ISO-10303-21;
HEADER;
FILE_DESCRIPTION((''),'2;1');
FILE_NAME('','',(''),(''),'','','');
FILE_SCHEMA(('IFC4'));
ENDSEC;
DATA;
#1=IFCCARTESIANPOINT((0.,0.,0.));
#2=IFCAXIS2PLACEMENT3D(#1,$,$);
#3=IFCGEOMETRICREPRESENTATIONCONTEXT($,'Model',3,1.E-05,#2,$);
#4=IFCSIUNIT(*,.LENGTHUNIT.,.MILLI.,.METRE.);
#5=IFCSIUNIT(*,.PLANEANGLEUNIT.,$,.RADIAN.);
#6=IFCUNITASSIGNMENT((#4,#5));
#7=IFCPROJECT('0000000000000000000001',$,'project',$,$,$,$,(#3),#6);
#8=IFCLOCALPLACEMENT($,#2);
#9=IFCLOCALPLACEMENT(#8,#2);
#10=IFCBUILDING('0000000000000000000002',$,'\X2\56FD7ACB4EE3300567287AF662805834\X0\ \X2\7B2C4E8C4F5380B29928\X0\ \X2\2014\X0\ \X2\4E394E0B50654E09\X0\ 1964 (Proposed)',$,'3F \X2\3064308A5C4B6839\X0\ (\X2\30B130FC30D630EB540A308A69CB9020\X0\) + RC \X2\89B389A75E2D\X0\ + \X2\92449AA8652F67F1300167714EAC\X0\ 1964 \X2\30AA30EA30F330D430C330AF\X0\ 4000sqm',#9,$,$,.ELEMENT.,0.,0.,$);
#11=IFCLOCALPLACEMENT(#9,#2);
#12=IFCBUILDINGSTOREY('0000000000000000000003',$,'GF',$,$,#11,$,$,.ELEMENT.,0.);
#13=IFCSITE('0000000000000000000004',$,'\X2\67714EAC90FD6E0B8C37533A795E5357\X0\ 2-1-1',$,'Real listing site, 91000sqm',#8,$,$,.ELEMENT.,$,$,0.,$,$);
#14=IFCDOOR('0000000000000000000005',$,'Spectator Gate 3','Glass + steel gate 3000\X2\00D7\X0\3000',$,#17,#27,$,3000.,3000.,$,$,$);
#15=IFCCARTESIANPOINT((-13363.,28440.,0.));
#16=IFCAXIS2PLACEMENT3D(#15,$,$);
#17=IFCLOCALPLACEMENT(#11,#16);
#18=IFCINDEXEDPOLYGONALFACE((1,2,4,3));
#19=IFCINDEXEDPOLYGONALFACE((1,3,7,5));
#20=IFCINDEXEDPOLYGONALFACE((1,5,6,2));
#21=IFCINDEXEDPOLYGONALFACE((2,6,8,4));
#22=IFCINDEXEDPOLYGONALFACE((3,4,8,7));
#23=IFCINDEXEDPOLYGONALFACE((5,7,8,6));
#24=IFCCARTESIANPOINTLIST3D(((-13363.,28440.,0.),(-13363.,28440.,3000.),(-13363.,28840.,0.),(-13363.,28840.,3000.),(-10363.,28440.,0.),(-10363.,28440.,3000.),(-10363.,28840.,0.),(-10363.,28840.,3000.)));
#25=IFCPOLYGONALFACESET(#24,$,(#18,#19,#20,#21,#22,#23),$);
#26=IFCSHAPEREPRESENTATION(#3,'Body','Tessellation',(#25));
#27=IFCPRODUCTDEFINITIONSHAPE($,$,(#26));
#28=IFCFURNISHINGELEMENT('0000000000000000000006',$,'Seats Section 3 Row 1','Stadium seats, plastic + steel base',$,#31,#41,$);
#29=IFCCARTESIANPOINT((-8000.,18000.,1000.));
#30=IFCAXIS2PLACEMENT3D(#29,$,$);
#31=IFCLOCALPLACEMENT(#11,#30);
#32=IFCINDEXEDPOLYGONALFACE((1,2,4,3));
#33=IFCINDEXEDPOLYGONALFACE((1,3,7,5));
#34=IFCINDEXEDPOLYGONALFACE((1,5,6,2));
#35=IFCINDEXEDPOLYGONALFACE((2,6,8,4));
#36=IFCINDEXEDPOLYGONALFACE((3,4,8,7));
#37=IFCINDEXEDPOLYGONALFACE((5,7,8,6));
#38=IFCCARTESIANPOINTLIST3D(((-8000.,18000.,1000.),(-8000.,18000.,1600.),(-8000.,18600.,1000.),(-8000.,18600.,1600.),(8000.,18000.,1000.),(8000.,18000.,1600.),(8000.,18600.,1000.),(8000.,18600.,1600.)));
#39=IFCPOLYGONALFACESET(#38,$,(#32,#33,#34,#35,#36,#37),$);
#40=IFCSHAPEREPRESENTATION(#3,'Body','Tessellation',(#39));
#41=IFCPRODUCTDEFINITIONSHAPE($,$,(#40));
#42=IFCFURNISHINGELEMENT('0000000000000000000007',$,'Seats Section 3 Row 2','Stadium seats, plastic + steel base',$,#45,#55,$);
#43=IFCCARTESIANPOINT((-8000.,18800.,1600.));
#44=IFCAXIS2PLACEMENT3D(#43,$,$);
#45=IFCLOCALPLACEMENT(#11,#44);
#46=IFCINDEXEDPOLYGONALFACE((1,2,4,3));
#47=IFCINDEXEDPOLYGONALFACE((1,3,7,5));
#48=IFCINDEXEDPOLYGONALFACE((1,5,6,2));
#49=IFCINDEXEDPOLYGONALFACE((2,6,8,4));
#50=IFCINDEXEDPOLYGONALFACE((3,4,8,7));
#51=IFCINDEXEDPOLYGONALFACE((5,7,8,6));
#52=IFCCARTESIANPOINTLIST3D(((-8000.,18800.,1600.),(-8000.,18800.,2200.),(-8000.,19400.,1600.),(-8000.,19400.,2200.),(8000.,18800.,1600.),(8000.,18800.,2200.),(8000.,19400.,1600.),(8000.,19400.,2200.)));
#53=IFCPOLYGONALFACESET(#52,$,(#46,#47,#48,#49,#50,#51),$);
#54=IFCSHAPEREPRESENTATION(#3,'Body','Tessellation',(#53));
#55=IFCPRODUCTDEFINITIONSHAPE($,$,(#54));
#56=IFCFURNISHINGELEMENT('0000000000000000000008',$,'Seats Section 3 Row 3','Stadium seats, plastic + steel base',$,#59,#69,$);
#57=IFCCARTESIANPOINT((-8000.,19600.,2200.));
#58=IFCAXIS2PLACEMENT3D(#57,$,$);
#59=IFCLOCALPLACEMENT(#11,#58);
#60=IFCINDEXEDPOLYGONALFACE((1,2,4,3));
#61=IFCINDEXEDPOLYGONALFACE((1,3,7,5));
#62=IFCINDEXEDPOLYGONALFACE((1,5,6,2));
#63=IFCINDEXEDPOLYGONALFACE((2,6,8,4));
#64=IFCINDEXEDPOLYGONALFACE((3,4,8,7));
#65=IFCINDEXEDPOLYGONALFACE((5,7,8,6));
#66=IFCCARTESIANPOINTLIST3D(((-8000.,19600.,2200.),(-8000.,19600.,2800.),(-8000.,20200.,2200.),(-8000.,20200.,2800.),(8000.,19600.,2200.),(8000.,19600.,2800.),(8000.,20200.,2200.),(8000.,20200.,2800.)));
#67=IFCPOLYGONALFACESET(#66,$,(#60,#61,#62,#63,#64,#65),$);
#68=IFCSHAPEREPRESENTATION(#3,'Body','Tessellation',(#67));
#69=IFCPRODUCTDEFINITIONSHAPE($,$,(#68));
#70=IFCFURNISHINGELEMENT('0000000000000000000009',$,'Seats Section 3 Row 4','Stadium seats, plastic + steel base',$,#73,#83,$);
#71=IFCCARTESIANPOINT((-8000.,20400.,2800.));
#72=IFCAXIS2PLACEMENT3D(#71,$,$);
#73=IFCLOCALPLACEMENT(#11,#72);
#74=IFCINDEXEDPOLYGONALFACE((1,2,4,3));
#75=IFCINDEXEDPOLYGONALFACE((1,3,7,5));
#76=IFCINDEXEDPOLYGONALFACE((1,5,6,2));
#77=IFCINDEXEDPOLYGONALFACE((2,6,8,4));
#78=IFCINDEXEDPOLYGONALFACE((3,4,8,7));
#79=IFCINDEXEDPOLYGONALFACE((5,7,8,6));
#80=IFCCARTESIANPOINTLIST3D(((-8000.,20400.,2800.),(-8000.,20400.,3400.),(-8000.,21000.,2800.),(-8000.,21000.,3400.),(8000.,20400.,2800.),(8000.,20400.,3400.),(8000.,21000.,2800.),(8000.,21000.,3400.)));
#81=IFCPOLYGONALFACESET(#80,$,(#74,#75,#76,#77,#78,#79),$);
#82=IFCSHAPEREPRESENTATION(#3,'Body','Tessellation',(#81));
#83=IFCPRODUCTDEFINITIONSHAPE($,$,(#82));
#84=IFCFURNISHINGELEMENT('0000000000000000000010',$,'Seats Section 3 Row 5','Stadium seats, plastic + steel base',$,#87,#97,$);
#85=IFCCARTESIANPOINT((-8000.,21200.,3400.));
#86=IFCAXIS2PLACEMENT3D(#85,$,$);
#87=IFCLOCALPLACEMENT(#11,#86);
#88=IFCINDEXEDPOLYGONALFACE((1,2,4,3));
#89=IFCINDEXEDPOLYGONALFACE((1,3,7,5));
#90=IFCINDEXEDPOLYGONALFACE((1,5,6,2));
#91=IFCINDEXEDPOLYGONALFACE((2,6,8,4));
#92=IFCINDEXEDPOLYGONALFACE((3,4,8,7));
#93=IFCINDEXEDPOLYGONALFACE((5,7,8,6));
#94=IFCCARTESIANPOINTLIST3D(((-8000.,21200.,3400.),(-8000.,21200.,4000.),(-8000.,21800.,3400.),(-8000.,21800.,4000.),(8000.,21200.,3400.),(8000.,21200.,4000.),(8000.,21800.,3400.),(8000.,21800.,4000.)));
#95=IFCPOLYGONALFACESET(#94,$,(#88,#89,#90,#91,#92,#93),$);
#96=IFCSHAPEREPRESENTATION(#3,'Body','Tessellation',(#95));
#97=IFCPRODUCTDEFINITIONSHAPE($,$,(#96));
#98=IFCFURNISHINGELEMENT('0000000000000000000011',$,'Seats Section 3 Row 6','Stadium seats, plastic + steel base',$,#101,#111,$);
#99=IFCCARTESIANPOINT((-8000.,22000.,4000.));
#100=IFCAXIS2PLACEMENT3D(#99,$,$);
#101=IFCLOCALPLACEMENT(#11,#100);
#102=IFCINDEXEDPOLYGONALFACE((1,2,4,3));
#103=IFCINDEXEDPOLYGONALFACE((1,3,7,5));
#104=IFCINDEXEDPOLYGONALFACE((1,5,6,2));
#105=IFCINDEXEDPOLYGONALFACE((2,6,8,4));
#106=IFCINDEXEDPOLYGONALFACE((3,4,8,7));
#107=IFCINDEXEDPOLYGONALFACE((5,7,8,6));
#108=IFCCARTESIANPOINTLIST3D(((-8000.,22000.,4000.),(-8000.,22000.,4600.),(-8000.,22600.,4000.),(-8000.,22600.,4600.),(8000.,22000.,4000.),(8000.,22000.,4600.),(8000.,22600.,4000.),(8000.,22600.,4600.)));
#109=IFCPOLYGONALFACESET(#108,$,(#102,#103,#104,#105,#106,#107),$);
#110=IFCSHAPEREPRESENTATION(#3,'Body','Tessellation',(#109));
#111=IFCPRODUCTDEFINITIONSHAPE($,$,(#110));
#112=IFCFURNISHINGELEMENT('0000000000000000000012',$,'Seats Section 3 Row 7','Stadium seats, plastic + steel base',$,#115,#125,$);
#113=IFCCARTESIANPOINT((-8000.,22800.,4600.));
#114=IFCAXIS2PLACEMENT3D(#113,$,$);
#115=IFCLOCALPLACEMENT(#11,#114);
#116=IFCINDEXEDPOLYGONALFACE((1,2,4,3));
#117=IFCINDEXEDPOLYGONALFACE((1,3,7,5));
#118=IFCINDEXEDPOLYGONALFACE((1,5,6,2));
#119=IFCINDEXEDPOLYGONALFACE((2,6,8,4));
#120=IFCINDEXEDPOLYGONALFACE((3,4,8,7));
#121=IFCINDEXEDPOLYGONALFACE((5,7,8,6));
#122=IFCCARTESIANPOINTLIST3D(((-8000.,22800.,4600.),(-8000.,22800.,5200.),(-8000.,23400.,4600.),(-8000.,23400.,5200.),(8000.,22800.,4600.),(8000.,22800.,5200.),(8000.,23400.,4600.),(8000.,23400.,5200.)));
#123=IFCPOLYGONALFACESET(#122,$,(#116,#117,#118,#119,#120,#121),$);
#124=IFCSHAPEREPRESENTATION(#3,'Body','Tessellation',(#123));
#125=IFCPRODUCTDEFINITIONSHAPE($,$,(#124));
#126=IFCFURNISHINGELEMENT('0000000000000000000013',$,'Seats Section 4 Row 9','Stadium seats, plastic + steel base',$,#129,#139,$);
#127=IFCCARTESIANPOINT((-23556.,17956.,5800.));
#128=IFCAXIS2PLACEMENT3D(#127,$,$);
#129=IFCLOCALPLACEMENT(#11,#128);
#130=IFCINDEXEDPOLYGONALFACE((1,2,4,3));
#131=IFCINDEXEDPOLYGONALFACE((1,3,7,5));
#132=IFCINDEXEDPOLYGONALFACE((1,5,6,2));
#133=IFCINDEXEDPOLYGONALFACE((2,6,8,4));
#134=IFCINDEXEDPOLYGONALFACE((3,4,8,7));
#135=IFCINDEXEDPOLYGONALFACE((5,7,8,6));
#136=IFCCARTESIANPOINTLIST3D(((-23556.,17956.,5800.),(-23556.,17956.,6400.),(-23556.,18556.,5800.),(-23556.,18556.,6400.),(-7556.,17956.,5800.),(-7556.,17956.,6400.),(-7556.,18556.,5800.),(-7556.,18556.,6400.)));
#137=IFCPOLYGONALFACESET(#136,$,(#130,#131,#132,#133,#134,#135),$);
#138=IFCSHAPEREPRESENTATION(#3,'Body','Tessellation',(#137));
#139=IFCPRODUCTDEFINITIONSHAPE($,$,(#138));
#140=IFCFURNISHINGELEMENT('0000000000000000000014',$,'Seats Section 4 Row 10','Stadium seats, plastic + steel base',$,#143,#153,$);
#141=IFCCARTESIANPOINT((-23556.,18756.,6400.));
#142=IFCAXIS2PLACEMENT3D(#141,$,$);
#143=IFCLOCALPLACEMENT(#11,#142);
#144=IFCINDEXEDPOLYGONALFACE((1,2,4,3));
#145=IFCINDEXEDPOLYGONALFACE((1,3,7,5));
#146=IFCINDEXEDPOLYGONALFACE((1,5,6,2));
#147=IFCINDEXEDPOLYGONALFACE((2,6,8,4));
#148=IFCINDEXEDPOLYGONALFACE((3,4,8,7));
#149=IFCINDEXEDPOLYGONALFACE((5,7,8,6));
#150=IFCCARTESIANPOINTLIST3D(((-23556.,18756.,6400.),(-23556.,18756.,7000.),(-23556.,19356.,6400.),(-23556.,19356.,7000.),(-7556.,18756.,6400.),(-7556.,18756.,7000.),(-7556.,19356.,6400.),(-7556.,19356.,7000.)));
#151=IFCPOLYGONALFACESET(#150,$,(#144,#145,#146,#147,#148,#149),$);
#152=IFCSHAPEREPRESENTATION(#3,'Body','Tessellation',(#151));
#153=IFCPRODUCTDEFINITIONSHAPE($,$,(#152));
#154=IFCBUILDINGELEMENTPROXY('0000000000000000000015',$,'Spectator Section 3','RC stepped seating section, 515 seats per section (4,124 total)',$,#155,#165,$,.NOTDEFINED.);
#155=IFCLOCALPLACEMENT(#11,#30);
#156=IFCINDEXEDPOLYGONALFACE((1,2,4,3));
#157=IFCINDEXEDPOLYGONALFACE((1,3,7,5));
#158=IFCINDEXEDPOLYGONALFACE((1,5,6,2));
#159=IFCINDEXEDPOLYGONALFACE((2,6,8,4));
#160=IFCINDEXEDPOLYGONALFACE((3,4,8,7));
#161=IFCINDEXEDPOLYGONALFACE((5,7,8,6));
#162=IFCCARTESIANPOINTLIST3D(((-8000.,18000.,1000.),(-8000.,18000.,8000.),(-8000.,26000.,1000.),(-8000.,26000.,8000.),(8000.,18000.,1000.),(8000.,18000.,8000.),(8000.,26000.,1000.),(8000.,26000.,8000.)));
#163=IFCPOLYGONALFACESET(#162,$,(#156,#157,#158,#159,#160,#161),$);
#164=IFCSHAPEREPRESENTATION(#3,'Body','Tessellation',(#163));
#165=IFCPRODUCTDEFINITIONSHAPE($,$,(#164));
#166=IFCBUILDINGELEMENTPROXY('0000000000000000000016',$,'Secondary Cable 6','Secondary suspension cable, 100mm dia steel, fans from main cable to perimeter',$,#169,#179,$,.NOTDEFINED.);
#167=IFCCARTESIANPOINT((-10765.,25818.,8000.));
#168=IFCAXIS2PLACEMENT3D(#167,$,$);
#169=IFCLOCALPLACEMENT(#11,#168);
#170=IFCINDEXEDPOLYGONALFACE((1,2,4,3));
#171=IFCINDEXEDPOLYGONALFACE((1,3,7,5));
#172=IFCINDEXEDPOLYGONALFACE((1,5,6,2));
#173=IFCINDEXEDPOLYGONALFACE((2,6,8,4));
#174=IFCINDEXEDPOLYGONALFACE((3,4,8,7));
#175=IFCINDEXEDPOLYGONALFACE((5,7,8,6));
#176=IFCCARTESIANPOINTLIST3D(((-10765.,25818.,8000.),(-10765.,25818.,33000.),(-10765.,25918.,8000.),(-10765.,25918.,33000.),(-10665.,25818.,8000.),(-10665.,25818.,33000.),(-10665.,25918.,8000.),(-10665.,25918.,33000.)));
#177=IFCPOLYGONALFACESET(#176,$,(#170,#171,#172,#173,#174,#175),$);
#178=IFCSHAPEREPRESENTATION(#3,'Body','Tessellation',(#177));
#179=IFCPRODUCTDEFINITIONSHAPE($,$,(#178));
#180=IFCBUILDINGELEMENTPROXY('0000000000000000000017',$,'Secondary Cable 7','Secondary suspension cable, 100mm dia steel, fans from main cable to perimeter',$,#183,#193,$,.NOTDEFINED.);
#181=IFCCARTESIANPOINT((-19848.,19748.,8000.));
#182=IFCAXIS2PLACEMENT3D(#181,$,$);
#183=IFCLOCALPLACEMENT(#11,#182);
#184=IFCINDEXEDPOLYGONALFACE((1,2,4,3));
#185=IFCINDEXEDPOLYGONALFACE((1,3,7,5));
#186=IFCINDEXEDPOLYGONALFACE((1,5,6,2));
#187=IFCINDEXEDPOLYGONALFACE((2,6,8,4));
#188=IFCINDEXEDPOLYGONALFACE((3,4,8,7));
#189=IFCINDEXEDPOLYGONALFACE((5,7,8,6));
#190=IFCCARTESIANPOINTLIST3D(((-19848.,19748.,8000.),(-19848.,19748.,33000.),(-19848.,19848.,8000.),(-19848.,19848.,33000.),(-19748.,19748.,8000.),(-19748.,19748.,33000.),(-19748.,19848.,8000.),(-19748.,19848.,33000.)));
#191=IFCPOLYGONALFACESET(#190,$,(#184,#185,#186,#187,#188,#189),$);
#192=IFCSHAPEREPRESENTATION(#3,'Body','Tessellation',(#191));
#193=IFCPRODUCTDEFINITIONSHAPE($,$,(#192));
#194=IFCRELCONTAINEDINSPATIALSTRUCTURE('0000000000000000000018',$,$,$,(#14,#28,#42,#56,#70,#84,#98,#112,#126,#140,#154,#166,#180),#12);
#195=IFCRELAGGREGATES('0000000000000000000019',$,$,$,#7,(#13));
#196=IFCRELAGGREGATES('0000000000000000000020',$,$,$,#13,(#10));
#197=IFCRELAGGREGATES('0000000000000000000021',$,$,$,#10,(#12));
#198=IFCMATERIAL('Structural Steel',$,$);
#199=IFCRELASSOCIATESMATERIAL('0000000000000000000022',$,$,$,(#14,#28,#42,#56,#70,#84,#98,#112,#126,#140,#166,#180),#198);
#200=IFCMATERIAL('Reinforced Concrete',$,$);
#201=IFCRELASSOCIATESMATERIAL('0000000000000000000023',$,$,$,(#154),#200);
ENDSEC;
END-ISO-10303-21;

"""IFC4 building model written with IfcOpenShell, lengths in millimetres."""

from ifc_helpers import new_model, si_unit, frame, frame_2d, origin, place, context, project, spatial, rectangle, extrude, material, element, save


model = new_model("IFC4")

# Units and contexts
model_context = context("Model", 3, precision=1e-05, world=origin())
ifc_project = project(units=[si_unit("LENGTHUNIT", "METRE", prefix="MILLI"), si_unit("PLANEANGLEUNIT", "RADIAN")], contexts=[model_context])

# Site, building, storey
site_placement = place(None, origin())
site = spatial("IfcSite", under=ifc_project, at=site_placement, Name="東京都渋谷区神南 2-1-1", ObjectType="Real listing site, 91000sqm", CompositionType="ELEMENT", RefElevation=0.0)
building_placement = place(site_placement, origin())
building = spatial("IfcBuilding", under=site, at=building_placement, Name="国立代々木競技場 第二体育館 — 丹下健三 1964 (Proposed)", ObjectType="3F つり屋根 (ケーブル吊り構造) + RC 観覧席 + 鉄骨支柱、東京 1964 オリンピック 4000sqm", CompositionType="ELEMENT", ElevationOfRefHeight=0.0, ElevationOfTerrain=0.0)
storey_placement = place(building_placement, origin())
storey = spatial("IfcBuildingStorey", under=building, at=storey_placement, Name="GF", CompositionType="ELEMENT", Elevation=0.0)

# Door
ifc_material_1 = material(Name="Structural Steel")
door_placement = place(storey_placement, frame((-13363.0, 28440.0, 0.0)))
element("IfcDoor", 1, at=door_placement, inside=storey, material=ifc_material_1, Name="Spectator Gate 3", Description="Glass + steel gate 3000×3000", OverallHeight=3000.0, OverallWidth=3000.0, context=model_context, shape_type="SweptSolid", body=[
    extrude(rectangle(XDim=3000.0, YDim=400.0, at=frame_2d((1500.0, 200.0))), frame((-13363.0, 28440.0, 0.0)), (0.0, 0.0, 1.0), 3000.0),
])

# Furnishing elements
furnishing_1_placement = place(storey_placement, frame((-8000.0, 18000.0, 1000.0)))
element("IfcFurnishingElement", 2, at=furnishing_1_placement, inside=storey, material=ifc_material_1, Name="Seats Section 3 Row 1", Description="Stadium seats, plastic + steel base", context=model_context, shape_type="SweptSolid", body=[
    extrude(rectangle(XDim=16000.0, YDim=600.0, at=frame_2d((8000.0, 300.0))), frame((-8000.0, 18000.0, 1000.0)), (0.0, 0.0, 1.0), 600.0),
])
furnishing_2_placement = place(storey_placement, frame((-8000.0, 18800.0, 1600.0)))
element("IfcFurnishingElement", 3, at=furnishing_2_placement, inside=storey, material=ifc_material_1, Name="Seats Section 3 Row 2", Description="Stadium seats, plastic + steel base", context=model_context, shape_type="SweptSolid", body=[
    extrude(rectangle(XDim=16000.0, YDim=600.0, at=frame_2d((8000.0, 300.0))), frame((-8000.0, 18800.0, 1600.0)), (0.0, 0.0, 1.0), 600.0),
])
furnishing_3_placement = place(storey_placement, frame((-8000.0, 19600.0, 2200.0)))
element("IfcFurnishingElement", 4, at=furnishing_3_placement, inside=storey, material=ifc_material_1, Name="Seats Section 3 Row 3", Description="Stadium seats, plastic + steel base", context=model_context, shape_type="SweptSolid", body=[
    extrude(rectangle(XDim=16000.0, YDim=600.0, at=frame_2d((8000.0, 300.0))), frame((-8000.0, 19600.0, 2200.0)), (0.0, 0.0, 1.0), 600.0),
])
furnishing_4_placement = place(storey_placement, frame((-8000.0, 20400.0, 2800.0)))
element("IfcFurnishingElement", 5, at=furnishing_4_placement, inside=storey, material=ifc_material_1, Name="Seats Section 3 Row 4", Description="Stadium seats, plastic + steel base", context=model_context, shape_type="SweptSolid", body=[
    extrude(rectangle(XDim=16000.0, YDim=600.0, at=frame_2d((8000.0, 300.0))), frame((-8000.0, 20400.0, 2800.0)), (0.0, 0.0, 1.0), 600.0),
])
furnishing_5_placement = place(storey_placement, frame((-8000.0, 21200.0, 3400.0)))
element("IfcFurnishingElement", 6, at=furnishing_5_placement, inside=storey, material=ifc_material_1, Name="Seats Section 3 Row 5", Description="Stadium seats, plastic + steel base", context=model_context, shape_type="SweptSolid", body=[
    extrude(rectangle(XDim=16000.0, YDim=600.0, at=frame_2d((8000.0, 300.0))), frame((-8000.0, 21200.0, 3400.0)), (0.0, 0.0, 1.0), 600.0),
])
furnishing_6_placement = place(storey_placement, frame((-8000.0, 22000.0, 4000.0)))
element("IfcFurnishingElement", 7, at=furnishing_6_placement, inside=storey, material=ifc_material_1, Name="Seats Section 3 Row 6", Description="Stadium seats, plastic + steel base", context=model_context, shape_type="SweptSolid", body=[
    extrude(rectangle(XDim=16000.0, YDim=600.0, at=frame_2d((8000.0, 300.0))), frame((-8000.0, 22000.0, 4000.0)), (0.0, 0.0, 1.0), 600.0),
])
furnishing_7_placement = place(storey_placement, frame((-8000.0, 22800.0, 4600.0)))
element("IfcFurnishingElement", 8, at=furnishing_7_placement, inside=storey, material=ifc_material_1, Name="Seats Section 3 Row 7", Description="Stadium seats, plastic + steel base", context=model_context, shape_type="SweptSolid", body=[
    extrude(rectangle(XDim=16000.0, YDim=600.0, at=frame_2d((8000.0, 300.0))), frame((-8000.0, 22800.0, 4600.0)), (0.0, 0.0, 1.0), 600.0),
])
furnishing_8_placement = place(storey_placement, frame((-23556.0, 17956.0, 5800.0)))
element("IfcFurnishingElement", 9, at=furnishing_8_placement, inside=storey, material=ifc_material_1, Name="Seats Section 4 Row 9", Description="Stadium seats, plastic + steel base", context=model_context, shape_type="SweptSolid", body=[
    extrude(rectangle(XDim=16000.0, YDim=600.0, at=frame_2d((8000.0, 300.0))), frame((-23556.0, 17956.0, 5800.0)), (0.0, 0.0, 1.0), 600.0),
])
furnishing_9_placement = place(storey_placement, frame((-23556.0, 18756.0, 6400.0)))
element("IfcFurnishingElement", 10, at=furnishing_9_placement, inside=storey, material=ifc_material_1, Name="Seats Section 4 Row 10", Description="Stadium seats, plastic + steel base", context=model_context, shape_type="SweptSolid", body=[
    extrude(rectangle(XDim=16000.0, YDim=600.0, at=frame_2d((8000.0, 300.0))), frame((-23556.0, 18756.0, 6400.0)), (0.0, 0.0, 1.0), 600.0),
])

# Building element proxies
ifc_material_2 = material(Name="Reinforced Concrete")
proxy_1_placement = place(storey_placement, frame((-8000.0, 18000.0, 1000.0)))
element("IfcBuildingElementProxy", 11, at=proxy_1_placement, inside=storey, material=ifc_material_2, Name="Spectator Section 3", Description="RC stepped seating section, 515 seats per section (4,124 total)", PredefinedType="NOTDEFINED", context=model_context, shape_type="SweptSolid", body=[
    extrude(rectangle(XDim=16000.0, YDim=8000.0, at=frame_2d((8000.0, 4000.0))), frame((-8000.0, 18000.0, 1000.0)), (0.0, 0.0, 1.0), 7000.0),
])
proxy_2_placement = place(storey_placement, frame((-10765.0, 25818.0, 8000.0)))
element("IfcBuildingElementProxy", 12, at=proxy_2_placement, inside=storey, material=ifc_material_1, Name="Secondary Cable 6", Description="Secondary suspension cable, 100mm dia steel, fans from main cable to perimeter", PredefinedType="NOTDEFINED", context=model_context, shape_type="SweptSolid", body=[
    extrude(rectangle(XDim=100.0, YDim=100.0, at=frame_2d((50.0, 50.0))), frame((-10765.0, 25818.0, 8000.0)), (0.0, 0.0, 1.0), 25000.0),
])
proxy_3_placement = place(storey_placement, frame((-19848.0, 19748.0, 8000.0)))
element("IfcBuildingElementProxy", 13, at=proxy_3_placement, inside=storey, material=ifc_material_1, Name="Secondary Cable 7", Description="Secondary suspension cable, 100mm dia steel, fans from main cable to perimeter", PredefinedType="NOTDEFINED", context=model_context, shape_type="SweptSolid", body=[
    extrude(rectangle(XDim=100.0, YDim=100.0, at=frame_2d((50.0, 50.0))), frame((-19848.0, 19748.0, 8000.0)), (0.0, 0.0, 1.0), 25000.0),
])

save(model, "model.ifc")
